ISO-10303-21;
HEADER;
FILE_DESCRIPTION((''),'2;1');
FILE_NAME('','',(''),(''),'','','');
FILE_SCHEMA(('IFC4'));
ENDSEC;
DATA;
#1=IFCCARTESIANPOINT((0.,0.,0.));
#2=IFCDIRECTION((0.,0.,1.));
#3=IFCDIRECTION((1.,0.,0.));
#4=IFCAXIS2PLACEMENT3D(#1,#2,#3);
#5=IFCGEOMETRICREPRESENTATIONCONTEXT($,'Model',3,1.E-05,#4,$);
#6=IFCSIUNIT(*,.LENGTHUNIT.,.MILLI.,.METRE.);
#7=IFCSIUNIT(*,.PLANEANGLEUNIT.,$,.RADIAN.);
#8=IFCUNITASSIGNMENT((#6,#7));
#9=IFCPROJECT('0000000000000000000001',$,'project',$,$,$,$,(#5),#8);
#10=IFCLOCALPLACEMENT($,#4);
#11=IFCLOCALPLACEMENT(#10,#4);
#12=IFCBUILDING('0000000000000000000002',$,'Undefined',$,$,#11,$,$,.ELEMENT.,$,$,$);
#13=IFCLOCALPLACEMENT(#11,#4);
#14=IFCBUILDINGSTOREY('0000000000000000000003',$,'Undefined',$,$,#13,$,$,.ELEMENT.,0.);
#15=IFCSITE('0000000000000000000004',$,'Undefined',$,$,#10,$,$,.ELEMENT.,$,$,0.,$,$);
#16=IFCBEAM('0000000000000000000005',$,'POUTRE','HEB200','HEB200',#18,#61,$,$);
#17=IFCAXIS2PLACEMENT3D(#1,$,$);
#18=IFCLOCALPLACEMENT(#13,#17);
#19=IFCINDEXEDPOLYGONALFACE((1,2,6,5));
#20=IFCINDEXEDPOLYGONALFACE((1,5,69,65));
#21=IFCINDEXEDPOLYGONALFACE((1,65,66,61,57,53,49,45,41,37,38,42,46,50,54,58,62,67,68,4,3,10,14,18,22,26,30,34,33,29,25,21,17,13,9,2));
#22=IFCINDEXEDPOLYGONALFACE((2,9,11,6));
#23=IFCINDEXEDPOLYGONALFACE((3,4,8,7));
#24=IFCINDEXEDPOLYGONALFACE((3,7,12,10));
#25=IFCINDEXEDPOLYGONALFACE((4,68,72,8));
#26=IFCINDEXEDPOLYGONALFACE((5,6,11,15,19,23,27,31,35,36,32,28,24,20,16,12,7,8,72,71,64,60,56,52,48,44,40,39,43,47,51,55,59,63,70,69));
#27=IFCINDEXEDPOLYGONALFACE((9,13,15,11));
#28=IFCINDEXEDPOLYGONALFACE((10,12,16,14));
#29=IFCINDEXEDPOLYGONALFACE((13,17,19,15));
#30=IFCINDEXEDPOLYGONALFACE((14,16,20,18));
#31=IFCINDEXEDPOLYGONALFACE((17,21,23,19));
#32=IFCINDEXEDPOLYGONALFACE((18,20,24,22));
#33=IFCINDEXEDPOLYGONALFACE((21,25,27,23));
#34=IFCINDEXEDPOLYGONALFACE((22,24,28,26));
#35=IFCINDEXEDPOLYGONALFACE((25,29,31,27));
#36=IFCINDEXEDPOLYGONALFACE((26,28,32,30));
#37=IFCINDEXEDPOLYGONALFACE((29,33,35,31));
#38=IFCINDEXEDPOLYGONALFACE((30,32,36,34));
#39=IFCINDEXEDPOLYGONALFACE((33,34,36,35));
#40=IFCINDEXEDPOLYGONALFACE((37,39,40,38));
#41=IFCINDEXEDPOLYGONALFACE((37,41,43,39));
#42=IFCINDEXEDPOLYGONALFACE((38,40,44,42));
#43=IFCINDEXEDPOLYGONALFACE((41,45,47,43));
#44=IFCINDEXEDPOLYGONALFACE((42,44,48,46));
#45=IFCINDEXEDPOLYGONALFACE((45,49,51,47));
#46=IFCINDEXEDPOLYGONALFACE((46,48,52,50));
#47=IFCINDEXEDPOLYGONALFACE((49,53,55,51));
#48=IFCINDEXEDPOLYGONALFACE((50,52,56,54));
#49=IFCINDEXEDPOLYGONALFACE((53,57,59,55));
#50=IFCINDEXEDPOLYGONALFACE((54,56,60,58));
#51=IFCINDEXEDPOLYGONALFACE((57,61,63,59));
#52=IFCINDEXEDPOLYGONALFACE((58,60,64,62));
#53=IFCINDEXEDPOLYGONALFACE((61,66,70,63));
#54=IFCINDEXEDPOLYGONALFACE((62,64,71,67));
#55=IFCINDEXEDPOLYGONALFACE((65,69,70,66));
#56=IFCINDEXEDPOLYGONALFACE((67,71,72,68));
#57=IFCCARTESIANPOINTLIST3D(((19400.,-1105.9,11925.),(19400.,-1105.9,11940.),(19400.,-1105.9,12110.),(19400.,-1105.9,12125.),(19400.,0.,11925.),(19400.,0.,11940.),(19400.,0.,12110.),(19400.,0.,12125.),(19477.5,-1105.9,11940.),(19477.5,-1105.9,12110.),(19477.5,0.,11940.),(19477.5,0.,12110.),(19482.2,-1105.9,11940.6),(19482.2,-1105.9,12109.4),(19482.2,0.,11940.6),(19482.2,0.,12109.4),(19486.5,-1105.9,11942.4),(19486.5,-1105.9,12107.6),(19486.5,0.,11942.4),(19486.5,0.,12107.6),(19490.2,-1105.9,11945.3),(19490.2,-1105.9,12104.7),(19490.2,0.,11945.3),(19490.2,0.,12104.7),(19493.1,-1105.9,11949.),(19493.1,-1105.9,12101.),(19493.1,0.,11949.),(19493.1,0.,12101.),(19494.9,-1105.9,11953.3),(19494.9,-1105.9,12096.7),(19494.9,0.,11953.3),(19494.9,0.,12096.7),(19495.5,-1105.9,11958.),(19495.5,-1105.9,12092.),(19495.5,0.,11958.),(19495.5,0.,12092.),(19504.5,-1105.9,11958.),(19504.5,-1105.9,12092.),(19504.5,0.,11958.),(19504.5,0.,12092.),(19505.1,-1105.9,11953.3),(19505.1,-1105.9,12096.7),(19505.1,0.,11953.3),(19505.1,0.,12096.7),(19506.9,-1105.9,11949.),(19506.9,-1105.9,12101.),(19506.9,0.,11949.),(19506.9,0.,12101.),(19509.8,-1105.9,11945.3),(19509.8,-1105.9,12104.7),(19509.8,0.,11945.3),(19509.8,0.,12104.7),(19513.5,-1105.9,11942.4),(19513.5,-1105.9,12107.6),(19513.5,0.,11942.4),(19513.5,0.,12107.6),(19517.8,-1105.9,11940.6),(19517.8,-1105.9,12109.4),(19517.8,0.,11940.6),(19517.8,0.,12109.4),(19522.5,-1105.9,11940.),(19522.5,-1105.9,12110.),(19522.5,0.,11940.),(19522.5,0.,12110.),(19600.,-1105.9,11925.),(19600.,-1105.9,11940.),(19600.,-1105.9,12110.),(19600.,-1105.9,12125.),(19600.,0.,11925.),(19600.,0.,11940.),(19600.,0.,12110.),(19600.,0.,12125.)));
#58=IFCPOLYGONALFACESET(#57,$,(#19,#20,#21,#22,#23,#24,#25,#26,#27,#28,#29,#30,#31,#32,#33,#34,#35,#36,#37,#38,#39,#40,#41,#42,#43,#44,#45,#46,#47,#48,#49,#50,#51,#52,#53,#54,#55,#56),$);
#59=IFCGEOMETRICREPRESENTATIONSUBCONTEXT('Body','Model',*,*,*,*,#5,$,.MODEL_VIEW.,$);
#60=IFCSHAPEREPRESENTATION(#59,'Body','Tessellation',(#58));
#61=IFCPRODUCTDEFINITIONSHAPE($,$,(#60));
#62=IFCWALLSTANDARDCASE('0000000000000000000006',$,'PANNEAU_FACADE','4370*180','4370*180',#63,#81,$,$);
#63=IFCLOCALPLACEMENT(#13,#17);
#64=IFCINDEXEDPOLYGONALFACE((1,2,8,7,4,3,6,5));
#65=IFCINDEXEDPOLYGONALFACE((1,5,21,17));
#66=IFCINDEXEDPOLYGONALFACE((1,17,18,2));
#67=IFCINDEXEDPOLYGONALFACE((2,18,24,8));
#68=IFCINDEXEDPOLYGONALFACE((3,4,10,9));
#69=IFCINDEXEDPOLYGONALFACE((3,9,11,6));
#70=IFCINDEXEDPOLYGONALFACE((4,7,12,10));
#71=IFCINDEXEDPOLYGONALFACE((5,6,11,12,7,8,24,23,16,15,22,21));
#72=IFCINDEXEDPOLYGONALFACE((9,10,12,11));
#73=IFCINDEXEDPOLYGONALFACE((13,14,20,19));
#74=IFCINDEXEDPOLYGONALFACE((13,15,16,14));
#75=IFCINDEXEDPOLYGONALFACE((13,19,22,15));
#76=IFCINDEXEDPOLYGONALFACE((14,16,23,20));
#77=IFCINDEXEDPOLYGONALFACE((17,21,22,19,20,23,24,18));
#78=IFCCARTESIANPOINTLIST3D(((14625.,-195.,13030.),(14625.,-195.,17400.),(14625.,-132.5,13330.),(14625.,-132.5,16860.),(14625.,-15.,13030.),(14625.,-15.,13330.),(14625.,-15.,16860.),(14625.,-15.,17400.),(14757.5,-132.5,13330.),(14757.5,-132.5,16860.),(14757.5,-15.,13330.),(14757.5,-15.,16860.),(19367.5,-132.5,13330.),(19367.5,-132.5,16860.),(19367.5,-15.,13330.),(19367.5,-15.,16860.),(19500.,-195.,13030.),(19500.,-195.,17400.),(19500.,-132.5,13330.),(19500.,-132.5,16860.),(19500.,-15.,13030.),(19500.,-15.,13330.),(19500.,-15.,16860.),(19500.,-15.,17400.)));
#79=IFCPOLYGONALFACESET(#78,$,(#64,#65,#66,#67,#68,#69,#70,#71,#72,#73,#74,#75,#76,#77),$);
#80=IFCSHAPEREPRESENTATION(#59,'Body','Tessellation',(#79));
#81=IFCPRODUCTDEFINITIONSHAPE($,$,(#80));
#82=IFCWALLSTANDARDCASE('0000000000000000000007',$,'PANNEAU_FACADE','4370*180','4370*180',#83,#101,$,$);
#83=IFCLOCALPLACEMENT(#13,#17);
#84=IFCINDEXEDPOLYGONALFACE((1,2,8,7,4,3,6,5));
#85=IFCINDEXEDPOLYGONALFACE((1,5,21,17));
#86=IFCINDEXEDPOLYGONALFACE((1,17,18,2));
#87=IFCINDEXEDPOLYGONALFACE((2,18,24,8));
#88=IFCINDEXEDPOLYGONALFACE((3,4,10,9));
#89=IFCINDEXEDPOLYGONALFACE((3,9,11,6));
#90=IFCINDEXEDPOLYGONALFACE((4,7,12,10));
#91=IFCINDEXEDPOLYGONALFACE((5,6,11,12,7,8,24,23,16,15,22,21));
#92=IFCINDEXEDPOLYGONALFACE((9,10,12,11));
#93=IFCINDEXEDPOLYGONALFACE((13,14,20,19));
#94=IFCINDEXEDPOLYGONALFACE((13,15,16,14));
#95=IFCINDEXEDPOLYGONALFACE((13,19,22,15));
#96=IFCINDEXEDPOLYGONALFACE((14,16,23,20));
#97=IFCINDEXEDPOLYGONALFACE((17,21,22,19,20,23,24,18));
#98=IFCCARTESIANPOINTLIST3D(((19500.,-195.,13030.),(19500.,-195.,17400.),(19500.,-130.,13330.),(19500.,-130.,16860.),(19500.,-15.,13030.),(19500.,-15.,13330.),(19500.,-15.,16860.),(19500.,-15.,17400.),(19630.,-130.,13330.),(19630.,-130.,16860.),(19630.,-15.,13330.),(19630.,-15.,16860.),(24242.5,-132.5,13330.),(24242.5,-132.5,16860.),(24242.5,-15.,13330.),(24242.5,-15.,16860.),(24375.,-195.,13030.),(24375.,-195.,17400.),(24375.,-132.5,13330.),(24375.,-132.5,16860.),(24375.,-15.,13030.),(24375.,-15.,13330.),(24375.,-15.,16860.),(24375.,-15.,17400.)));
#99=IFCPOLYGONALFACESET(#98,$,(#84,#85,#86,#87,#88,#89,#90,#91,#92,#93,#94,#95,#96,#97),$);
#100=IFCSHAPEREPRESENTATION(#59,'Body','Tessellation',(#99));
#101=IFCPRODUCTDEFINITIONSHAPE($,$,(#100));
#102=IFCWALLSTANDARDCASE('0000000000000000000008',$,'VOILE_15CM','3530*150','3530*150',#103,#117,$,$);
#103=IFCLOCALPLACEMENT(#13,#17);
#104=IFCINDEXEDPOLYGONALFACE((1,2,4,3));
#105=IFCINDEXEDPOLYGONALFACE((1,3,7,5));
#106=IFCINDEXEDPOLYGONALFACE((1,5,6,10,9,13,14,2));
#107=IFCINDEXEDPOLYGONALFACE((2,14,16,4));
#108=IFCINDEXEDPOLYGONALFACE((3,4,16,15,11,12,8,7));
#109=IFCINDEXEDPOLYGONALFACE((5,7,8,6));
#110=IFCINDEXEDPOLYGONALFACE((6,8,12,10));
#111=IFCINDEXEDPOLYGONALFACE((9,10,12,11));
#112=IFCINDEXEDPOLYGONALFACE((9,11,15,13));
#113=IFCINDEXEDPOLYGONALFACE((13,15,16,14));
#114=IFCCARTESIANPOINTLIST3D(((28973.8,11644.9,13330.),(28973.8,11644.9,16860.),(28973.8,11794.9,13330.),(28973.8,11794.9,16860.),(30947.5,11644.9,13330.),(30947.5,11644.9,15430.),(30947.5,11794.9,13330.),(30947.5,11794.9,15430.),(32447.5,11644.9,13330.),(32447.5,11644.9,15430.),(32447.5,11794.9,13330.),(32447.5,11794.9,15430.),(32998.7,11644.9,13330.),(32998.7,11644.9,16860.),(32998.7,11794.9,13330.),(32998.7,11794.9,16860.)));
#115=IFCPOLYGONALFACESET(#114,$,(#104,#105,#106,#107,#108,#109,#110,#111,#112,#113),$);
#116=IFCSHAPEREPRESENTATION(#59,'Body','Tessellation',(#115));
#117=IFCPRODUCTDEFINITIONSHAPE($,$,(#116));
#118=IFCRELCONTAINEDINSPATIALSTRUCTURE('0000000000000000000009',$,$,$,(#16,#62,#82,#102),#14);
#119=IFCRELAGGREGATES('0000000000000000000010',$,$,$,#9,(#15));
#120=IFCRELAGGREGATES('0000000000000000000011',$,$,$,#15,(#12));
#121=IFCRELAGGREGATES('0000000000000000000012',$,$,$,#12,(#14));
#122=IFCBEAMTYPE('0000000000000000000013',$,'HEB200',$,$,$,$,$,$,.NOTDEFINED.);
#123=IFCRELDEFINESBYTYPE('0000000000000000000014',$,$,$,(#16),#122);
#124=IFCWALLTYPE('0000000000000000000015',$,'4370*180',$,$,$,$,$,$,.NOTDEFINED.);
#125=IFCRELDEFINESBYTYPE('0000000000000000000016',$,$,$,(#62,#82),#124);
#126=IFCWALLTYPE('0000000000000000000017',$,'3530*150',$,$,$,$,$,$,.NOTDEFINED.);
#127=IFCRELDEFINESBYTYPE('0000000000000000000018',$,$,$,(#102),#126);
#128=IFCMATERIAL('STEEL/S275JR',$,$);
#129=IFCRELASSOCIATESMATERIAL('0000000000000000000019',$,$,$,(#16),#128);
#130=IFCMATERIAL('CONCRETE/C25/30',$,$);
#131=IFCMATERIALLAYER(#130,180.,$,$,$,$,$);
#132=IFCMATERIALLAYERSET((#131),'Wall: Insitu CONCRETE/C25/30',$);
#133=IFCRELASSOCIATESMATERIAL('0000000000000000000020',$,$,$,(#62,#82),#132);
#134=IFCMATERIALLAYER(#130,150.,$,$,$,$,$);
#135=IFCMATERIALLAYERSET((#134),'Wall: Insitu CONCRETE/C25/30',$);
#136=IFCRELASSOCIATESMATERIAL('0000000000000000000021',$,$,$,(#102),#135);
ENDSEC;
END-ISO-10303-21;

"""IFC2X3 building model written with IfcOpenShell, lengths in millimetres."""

from ifc_helpers import new_model, si_unit, frame, frame_2d, origin_with_axes, origin_2d_with_axis, place, context, subcontext, project, spatial, polyline, rectangle, i_section, outline, extrude, boolean, material, layer, layer_set, layer_usage, type_object, element, save


model = new_model("IFC2X3")

# Units and contexts
model_context = context("Model", 3, precision=1e-05, world=origin_with_axes())
body_context = subcontext(model_context, "Body", "Model", "MODEL_VIEW")
ifc_project = project(units=[si_unit("LENGTHUNIT", "METRE", prefix="MILLI"), si_unit("PLANEANGLEUNIT", "RADIAN")], contexts=[model_context])

# Site, building, storey
site_placement = place(None, origin_with_axes())
site = spatial("IfcSite", under=ifc_project, at=site_placement, Name="Undefined", CompositionType="ELEMENT", RefElevation=0.0)
building_placement = place(site_placement, origin_with_axes())
building = spatial("IfcBuilding", under=site, at=building_placement, Name="Undefined", CompositionType="ELEMENT")
storey_placement = place(building_placement, origin_with_axes())
storey = spatial("IfcBuildingStorey", under=building, at=storey_placement, Name="Undefined", CompositionType="ELEMENT", Elevation=0.0)

# Shared definitions
ifc_material_1 = material(Name="CONCRETE/C25/30")
ifc_material_2 = material(Name="STEEL/S275JR")

# Beam
beam_type_1 = type_object("IfcBeamType", Name="HEB200", PredefinedType="NOTDEFINED")
beam_1_placement = place(storey_placement, frame((19500.0, 0.0, 12025.0), z_axis=(0.0, 0.0, 1.0), x_axis=(0.0, -1.0, 0.0)))
element("IfcBeam", 1, at=beam_1_placement, inside=storey, type_object=beam_type_1, material=ifc_material_2, Name="POUTRE", Description="HEB200", ObjectType="HEB200", context=body_context, shape_type="SweptSolid", body=[
    extrude(i_section(OverallWidth=200.0, OverallDepth=200.0, WebThickness=9.0, FlangeThickness=15.0, FilletRadius=18.0, at=origin_2d_with_axis()), frame((1105.9, 0.0, 0.0), z_axis=(-1.0, 0.0, 0.0), x_axis=(0.0, -1.0, 0.0)), (0.0, 0.0, 1.0), 1105.9),
])

# Walls
ifc_layer_1 = layer(ifc_material_1, 180.0)
ifc_layer_set_1 = layer_set([ifc_layer_1], Name="Wall: Insitu CONCRETE/C25/30")
ifc_layer_usage_1 = layer_usage(ifc_layer_set_1, "AXIS2", "POSITIVE", -90.0)
wall_type_1 = type_object("IfcWallType", Name="4370*180", PredefinedType="NOTDEFINED")
wall_1_placement = place(storey_placement, frame((19500.0, -105.0, 13030.0), z_axis=(0.0, 0.0, 1.0), x_axis=(-1.0, 0.0, 0.0)))
element("IfcWallStandardCase", 2, at=wall_1_placement, inside=storey, type_object=wall_type_1, material=ifc_layer_usage_1, Name="PANNEAU_FACADE", Description="4370*180", ObjectType="4370*180", context=body_context, shape_type="CSG", body=[
    boolean("DIFFERENCE", boolean("DIFFERENCE", extrude(rectangle(XDim=4875.0, YDim=180.0, at=frame_2d((0.0, 2437.5), x_axis=(0.0, -1.0))), frame((0.0, 0.0, 0.0), z_axis=(0.0, 0.0, 1.0), x_axis=(0.0, -1.0, 0.0)), (0.0, 0.0, 1.0), 4370.0), extrude(rectangle(XDim=265.0, YDim=265.0, at=origin_2d_with_axis()), frame((0.0, -105.0, 3830.0), z_axis=(0.0, 0.0, -1.0), x_axis=(1.0, 0.0, 0.0)), (0.0, 0.0, 1.0), 3530.0)), extrude(rectangle(XDim=265.0, YDim=265.0, at=origin_2d_with_axis()), frame((4875.0, -105.0, 3830.0), z_axis=(0.0, 0.0, -1.0), x_axis=(1.0, 0.0, 0.0)), (0.0, 0.0, 1.0), 3530.0)),
])
ifc_layer_usage_2 = layer_usage(ifc_layer_set_1, "AXIS2", "POSITIVE", -90.0)
wall_2_placement = place(storey_placement, frame((24375.0, -105.0, 13030.0), z_axis=(0.0, 0.0, 1.0), x_axis=(-1.0, 0.0, 0.0)))
element("IfcWallStandardCase", 3, at=wall_2_placement, inside=storey, type_object=wall_type_1, material=ifc_layer_usage_2, Name="PANNEAU_FACADE", Description="4370*180", ObjectType="4370*180", context=body_context, shape_type="CSG", body=[
    boolean("DIFFERENCE", boolean("DIFFERENCE", extrude(rectangle(XDim=4875.0, YDim=180.0, at=frame_2d((0.0, 2437.5), x_axis=(0.0, -1.0))), frame((0.0, 0.0, 0.0), z_axis=(0.0, 0.0, 1.0), x_axis=(0.0, -1.0, 0.0)), (0.0, 0.0, 1.0), 4370.0), extrude(rectangle(XDim=260.0, YDim=260.0, at=origin_2d_with_axis()), frame((4875.0, -105.0, 3830.0), z_axis=(0.0, 0.0, -1.0), x_axis=(1.0, 0.0, 0.0)), (0.0, 0.0, 1.0), 3530.0)), extrude(rectangle(XDim=265.0, YDim=265.0, at=origin_2d_with_axis()), frame((0.0, -105.0, 3830.0), z_axis=(0.0, 0.0, -1.0), x_axis=(1.0, 0.0, 0.0)), (0.0, 0.0, 1.0), 3530.0)),
])
ifc_layer_2 = layer(ifc_material_1, 150.0)
ifc_layer_set_2 = layer_set([ifc_layer_2], Name="Wall: Insitu CONCRETE/C25/30")
ifc_layer_usage_3 = layer_usage(ifc_layer_set_2, "AXIS2", "POSITIVE", -75.0)
wall_type_2 = type_object("IfcWallType", Name="3530*150", PredefinedType="NOTDEFINED")
wall_3_placement = place(storey_placement, frame((28973.8, 11719.9, 13330.0), z_axis=(0.0, 0.0, 1.0), x_axis=(1.0, 0.0, 0.0)))
element("IfcWallStandardCase", 4, at=wall_3_placement, inside=storey, type_object=wall_type_2, material=ifc_layer_usage_3, Name="VOILE_15CM", Description="3530*150", ObjectType="3530*150", context=body_context, shape_type="CSG", body=[
    boolean("DIFFERENCE", extrude(rectangle(XDim=4025.0, YDim=150.0, at=frame_2d((0.0, 2012.5), x_axis=(0.0, -1.0))), frame((0.0, 0.0, 0.0), z_axis=(0.0, 0.0, 1.0), x_axis=(0.0, -1.0, 0.0)), (0.0, 0.0, 1.0), 3530.0), extrude(outline(polyline([(0.0, 0.0), (2100.0, 0.0), (2100.0, 1500.0), (0.0, 1500.0), (0.0, 0.0)])), frame((1973.7, 85.0, 2100.0), z_axis=(0.0, -1.0, 0.0), x_axis=(0.0, 0.0, -1.0)), (0.0, 0.0, 1.0), 170.0)),
])

save(model, "model.ifc")
